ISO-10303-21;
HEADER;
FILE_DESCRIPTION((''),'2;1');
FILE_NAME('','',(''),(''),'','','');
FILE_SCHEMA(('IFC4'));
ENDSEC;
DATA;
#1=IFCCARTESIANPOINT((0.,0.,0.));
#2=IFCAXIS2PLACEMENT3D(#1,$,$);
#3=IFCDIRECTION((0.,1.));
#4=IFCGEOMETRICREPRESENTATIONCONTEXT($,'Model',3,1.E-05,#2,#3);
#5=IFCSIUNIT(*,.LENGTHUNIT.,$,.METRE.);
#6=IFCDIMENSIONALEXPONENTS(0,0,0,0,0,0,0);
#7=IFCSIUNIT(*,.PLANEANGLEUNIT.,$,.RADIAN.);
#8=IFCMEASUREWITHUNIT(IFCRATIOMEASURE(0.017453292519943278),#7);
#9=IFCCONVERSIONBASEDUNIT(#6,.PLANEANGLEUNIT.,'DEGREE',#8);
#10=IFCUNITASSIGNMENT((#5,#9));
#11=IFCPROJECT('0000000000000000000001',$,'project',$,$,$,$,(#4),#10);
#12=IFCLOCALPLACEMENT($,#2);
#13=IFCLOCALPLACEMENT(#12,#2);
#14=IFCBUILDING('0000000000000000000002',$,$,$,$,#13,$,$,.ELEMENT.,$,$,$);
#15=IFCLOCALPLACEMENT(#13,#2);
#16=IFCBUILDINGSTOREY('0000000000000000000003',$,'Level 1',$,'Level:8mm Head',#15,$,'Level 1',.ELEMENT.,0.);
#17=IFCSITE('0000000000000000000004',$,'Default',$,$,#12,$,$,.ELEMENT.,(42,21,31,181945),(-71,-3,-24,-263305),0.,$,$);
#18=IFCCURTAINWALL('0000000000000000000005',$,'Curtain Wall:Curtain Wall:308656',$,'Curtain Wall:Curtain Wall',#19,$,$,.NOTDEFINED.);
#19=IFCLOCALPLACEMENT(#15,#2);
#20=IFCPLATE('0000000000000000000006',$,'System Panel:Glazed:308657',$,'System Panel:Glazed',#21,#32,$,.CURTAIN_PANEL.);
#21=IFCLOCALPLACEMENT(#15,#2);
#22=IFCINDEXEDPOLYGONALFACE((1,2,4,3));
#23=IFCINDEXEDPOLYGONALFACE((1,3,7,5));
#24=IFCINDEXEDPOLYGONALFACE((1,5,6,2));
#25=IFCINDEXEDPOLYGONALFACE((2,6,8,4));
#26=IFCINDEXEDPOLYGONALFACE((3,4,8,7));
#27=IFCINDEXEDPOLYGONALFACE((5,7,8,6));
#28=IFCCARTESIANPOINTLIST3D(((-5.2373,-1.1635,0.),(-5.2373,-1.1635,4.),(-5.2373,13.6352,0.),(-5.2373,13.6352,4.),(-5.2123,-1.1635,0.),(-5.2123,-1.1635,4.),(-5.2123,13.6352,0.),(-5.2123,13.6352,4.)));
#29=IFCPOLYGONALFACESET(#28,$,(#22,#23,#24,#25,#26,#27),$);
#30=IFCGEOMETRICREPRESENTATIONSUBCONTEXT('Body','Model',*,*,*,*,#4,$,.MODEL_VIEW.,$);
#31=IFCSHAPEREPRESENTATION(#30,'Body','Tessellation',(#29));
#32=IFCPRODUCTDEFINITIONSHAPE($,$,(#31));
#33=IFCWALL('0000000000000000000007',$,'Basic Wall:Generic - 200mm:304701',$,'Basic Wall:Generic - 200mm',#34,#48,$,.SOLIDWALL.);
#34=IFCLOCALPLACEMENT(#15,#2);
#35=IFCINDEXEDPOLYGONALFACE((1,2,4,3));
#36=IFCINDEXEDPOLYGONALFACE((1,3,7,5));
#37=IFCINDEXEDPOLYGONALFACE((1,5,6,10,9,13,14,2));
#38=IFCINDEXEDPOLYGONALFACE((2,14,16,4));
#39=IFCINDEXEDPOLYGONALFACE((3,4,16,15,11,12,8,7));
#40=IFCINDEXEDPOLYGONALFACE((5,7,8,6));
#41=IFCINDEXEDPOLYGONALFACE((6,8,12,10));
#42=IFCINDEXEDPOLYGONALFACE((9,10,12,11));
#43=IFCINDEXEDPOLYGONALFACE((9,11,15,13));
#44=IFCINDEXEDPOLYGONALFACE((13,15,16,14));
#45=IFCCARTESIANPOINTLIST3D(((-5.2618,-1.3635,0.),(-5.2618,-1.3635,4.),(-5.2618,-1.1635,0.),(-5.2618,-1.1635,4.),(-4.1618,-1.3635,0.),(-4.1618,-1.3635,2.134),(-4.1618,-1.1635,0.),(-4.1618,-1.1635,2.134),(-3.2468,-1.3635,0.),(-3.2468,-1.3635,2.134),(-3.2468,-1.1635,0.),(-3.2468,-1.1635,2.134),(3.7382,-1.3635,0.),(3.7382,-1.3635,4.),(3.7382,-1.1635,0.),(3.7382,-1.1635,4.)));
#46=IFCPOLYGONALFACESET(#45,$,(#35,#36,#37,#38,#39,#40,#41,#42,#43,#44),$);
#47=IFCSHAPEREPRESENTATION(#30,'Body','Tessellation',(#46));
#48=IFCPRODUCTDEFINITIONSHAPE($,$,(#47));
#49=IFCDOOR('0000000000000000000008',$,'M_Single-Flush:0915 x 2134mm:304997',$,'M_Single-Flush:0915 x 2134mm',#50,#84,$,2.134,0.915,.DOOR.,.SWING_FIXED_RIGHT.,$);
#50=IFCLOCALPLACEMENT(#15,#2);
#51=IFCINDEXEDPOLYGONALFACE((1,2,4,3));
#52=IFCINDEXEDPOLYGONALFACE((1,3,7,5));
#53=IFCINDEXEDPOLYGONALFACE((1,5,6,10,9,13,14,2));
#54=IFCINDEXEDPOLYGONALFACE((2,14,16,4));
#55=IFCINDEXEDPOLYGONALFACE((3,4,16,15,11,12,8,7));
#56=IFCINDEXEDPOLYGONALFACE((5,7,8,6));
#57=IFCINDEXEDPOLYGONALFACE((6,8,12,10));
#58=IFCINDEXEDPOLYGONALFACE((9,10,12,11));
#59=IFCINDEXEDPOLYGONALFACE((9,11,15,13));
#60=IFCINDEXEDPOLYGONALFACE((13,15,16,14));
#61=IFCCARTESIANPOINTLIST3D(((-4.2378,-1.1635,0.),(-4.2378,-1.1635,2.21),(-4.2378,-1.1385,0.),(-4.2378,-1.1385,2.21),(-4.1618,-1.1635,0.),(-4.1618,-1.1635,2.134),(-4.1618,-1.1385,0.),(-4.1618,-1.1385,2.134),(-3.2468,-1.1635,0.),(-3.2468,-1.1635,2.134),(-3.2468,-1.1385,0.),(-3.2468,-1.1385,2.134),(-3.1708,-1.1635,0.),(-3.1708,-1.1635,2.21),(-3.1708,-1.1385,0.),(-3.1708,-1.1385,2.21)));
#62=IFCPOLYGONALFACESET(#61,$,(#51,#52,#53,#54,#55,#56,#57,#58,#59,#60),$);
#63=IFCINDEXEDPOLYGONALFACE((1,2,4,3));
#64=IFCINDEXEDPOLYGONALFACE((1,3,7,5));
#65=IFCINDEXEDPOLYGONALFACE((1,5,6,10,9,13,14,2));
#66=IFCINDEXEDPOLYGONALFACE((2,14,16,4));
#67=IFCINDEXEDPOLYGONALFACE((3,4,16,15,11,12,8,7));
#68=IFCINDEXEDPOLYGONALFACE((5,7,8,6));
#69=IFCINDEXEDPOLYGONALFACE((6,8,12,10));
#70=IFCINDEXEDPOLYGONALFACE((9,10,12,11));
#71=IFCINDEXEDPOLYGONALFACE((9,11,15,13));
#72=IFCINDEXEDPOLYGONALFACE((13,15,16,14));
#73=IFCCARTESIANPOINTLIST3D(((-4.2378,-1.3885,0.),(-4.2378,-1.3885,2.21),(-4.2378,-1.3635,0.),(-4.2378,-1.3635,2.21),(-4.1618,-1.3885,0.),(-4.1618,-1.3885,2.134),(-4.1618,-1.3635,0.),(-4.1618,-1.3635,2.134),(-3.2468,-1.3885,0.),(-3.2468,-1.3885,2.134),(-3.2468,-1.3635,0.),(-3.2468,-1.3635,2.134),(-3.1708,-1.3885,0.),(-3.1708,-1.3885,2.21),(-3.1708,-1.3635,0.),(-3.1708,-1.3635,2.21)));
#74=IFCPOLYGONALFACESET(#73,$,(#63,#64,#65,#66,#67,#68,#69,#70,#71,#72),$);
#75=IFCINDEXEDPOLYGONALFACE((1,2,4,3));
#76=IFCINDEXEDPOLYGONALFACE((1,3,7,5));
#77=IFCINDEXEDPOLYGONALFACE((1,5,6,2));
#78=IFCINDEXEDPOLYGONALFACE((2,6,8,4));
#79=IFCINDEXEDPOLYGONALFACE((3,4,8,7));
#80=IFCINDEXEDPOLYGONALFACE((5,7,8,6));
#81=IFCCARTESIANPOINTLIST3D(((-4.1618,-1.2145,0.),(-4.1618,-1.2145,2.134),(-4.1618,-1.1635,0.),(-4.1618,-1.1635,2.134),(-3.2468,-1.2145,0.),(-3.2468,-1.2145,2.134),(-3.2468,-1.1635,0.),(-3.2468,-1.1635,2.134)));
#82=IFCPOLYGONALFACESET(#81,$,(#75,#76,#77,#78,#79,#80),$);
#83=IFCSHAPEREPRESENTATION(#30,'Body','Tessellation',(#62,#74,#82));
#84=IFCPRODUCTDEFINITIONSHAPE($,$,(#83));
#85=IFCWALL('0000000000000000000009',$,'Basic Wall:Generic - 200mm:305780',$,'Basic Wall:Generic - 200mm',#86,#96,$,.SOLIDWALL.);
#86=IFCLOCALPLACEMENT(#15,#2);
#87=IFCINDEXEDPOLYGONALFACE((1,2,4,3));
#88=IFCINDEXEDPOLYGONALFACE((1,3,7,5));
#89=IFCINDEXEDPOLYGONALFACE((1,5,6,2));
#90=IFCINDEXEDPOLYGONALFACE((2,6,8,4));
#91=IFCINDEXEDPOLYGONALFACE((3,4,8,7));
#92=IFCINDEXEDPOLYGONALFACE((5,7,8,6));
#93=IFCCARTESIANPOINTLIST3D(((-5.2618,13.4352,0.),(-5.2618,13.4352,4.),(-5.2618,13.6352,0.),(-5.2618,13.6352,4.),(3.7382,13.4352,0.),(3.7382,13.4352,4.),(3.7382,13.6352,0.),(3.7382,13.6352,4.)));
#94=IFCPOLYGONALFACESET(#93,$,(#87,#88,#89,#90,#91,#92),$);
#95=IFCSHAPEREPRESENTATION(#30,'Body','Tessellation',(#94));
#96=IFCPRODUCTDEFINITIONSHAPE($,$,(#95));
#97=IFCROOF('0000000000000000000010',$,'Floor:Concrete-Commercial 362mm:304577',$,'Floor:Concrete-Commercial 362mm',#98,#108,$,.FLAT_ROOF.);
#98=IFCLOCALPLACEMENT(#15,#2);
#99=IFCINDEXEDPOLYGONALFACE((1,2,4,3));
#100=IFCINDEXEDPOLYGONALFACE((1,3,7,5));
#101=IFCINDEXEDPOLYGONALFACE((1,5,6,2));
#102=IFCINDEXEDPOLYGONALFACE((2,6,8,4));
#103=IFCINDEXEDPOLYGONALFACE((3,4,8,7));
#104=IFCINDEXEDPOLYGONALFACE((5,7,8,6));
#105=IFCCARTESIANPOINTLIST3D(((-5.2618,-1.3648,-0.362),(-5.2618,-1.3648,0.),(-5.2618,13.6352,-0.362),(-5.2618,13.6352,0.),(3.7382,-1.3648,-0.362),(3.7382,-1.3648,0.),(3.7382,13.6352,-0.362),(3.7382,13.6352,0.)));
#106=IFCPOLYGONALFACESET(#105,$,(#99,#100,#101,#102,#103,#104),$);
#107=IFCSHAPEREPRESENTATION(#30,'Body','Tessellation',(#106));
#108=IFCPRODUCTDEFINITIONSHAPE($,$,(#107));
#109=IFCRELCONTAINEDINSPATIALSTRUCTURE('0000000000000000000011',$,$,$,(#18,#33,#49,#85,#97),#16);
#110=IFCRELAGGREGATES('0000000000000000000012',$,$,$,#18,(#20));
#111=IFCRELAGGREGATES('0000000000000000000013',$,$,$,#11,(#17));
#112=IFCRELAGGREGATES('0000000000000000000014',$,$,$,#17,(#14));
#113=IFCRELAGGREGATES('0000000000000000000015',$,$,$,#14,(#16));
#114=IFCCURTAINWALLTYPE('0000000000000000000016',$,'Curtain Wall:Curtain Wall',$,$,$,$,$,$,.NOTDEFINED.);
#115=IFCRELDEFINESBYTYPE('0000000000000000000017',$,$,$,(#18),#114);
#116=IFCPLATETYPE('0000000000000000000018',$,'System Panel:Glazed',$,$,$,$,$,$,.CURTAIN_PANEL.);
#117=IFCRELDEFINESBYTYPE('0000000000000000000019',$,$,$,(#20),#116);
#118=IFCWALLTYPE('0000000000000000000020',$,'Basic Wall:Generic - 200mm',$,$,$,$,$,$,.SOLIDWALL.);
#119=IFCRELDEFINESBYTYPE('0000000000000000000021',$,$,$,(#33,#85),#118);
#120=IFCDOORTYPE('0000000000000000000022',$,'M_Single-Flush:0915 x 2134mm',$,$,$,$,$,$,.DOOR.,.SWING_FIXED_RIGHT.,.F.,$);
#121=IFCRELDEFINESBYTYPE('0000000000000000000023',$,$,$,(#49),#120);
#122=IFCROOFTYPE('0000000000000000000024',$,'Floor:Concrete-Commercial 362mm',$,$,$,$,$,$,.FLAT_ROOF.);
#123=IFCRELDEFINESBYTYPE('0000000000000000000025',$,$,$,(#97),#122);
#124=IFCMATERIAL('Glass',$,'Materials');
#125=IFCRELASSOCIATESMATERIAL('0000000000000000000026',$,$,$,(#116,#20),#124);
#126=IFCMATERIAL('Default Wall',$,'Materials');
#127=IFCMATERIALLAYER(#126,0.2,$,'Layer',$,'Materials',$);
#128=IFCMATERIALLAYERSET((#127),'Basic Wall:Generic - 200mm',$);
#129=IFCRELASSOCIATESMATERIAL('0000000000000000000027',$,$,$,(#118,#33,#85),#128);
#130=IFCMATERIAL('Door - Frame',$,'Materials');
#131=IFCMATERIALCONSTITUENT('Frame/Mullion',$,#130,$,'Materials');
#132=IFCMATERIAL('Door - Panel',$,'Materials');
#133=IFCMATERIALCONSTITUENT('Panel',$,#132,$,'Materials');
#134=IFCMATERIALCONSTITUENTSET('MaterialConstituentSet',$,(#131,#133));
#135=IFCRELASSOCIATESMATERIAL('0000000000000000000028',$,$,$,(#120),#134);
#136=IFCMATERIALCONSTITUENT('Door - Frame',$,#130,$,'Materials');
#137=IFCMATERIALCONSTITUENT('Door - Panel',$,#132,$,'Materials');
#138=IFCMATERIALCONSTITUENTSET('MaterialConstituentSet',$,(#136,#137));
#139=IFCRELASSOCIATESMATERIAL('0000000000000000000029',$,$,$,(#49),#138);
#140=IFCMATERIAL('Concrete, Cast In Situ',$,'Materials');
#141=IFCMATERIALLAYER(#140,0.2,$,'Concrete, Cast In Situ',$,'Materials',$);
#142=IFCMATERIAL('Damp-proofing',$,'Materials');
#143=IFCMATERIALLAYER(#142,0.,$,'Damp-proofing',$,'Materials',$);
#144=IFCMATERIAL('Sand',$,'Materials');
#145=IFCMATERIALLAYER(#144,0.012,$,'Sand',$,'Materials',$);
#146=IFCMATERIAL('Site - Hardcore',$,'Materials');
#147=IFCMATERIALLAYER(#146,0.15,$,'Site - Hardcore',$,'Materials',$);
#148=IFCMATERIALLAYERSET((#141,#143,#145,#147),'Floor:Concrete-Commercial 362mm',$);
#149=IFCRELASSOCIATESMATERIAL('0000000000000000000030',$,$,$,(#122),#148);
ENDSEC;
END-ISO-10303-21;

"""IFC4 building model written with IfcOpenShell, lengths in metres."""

from ifc_helpers import new_model, entity, si_unit, converted_unit, direction, frame, frame_2d, origin, origin_2d_with_axis, place, context, subcontext, project, spatial, polyline, rectangle, outline, extrude, source, transform, mapped, material, layer, layer_set, layer_usage, constituent, constituent_set, type_object, type_shapes, element, fill, aggregate, save


model = new_model("IFC4")

# Units and contexts
model_context = context("Model", 3, precision=1e-05, world=origin(), true_north=direction((0.0, 1.0)))
body_context = subcontext(model_context, "Body", "Model", "MODEL_VIEW")
ifc_project = project(units=[si_unit("LENGTHUNIT", "METRE"), converted_unit("PLANEANGLEUNIT", "DEGREE", entity("IfcRatioMeasure", 0.017453292519943278), si_unit("PLANEANGLEUNIT", "RADIAN"), dimensions=[0, 0, 0, 0, 0, 0, 0])], contexts=[model_context])

# Site, building, storey
site_placement = place(None, origin())
site = spatial("IfcSite", under=ifc_project, at=site_placement, Name="Default", CompositionType="ELEMENT", RefLatitude=(42, 21, 31, 181945), RefLongitude=(-71, -3, -24, -263305), RefElevation=0.0)
building_placement = place(site_placement, origin())
building = spatial("IfcBuilding", under=site, at=building_placement, CompositionType="ELEMENT")
storey_placement = place(building_placement, origin())
storey = spatial("IfcBuildingStorey", under=building, at=storey_placement, Name="Level 1", ObjectType="Level:8mm Head", LongName="Level 1", CompositionType="ELEMENT", Elevation=0.0)

# Curtain wall, plate
curtain_wall_type = type_object("IfcCurtainWallType", Name="Curtain Wall:Curtain Wall", PredefinedType="NOTDEFINED")
ifc_material_1 = material(Name="Glass", Category="Materials")
curtain_wall_1_placement = place(storey_placement, origin())
curtain_wall_1 = element("IfcCurtainWall", 1, at=curtain_wall_1_placement, inside=storey, type_object=curtain_wall_type, Name="Curtain Wall:Curtain Wall:308656", ObjectType="Curtain Wall:Curtain Wall", PredefinedType="NOTDEFINED")
plate_type_1 = type_object("IfcPlateType", Name="System Panel:Glazed", PredefinedType="CURTAIN_PANEL", material=ifc_material_1)
shared_shape_1 = source(origin(), body_context, "Body", "SweptSolid", [
    extrude(rectangle(XDim=0.025, YDim=14.7987, at=origin_2d_with_axis()), frame((7.3993, 0.0125, 0.0), z_axis=(0.0, 0.0, 1.0), x_axis=(0.0, 1.0, 0.0)), (0.0, 0.0, 1.0), 4.0),
])
type_shapes(plate_type_1, [shared_shape_1])
plate_1_placement = place(curtain_wall_1_placement, frame((-5.2373, 13.6352, 0.0), z_axis=(0.0, 0.0, 1.0), x_axis=(0.0, -1.0, 0.0)))
plate_1 = element("IfcPlate", 2, at=plate_1_placement, type_object=plate_type_1, material=ifc_material_1, Name="System Panel:Glazed:308657", ObjectType="System Panel:Glazed", PredefinedType="CURTAIN_PANEL", context=body_context, shape_type="MappedRepresentation", body=[
    mapped(shared_shape_1, transform((0.0, 0.0, 0.0), scale=1.0)),
])
aggregate(curtain_wall_1, [plate_1])

# Wall, opening, door
ifc_material_2 = material(Name="Default Wall", Category="Materials")
ifc_layer_1 = layer(ifc_material_2, 0.2, Name="Layer", Category="Materials")
ifc_layer_set_1 = layer_set([ifc_layer_1], Name="Basic Wall:Generic - 200mm")
ifc_layer_usage_1 = layer_usage(ifc_layer_set_1, "AXIS2", "NEGATIVE", 0.1)
wall_type = type_object("IfcWallType", Name="Basic Wall:Generic - 200mm", PredefinedType="SOLIDWALL", material=ifc_layer_set_1)
wall_1_placement = place(storey_placement, frame((-5.2618, -1.2635, 0.0)))
wall_1 = element("IfcWall", 3, at=wall_1_placement, inside=storey, type_object=wall_type, material=ifc_layer_usage_1, Name="Basic Wall:Generic - 200mm:304701", ObjectType="Basic Wall:Generic - 200mm", PredefinedType="SOLIDWALL", context=body_context, shape_type="SweptSolid", body=[
    extrude(rectangle(XDim=9.0, YDim=0.2, at=frame_2d((4.5, 0.0), x_axis=(1.0, 0.0))), origin(), (0.0, 0.0, 1.0), 4.0),
])
opening_placement = place(wall_1_placement, frame((1.1, -0.1, 0.0)))
opening = element("IfcOpeningElement", 4, at=opening_placement, cuts=wall_1, PredefinedType="OPENING", context=body_context, shape_type="SweptSolid", body=[
    extrude(rectangle(XDim=0.915, YDim=2.134, at=frame_2d((1.067, 0.4575), x_axis=(0.0, 1.0))), frame((0.0, 0.0, 0.0), z_axis=(0.0, 1.0, 0.0), x_axis=(0.0, 0.0, 1.0)), (0.0, 0.0, 1.0), 0.2),
])
ifc_material_3 = material(Name="Door - Frame", Category="Materials")
ifc_constituent_1 = constituent(ifc_material_3, Name="Door - Frame", Category="Materials")
ifc_material_4 = material(Name="Door - Panel", Category="Materials")
ifc_constituent_2 = constituent(ifc_material_4, Name="Door - Panel", Category="Materials")
ifc_constituent_set_1 = constituent_set(constituents=[ifc_constituent_1, ifc_constituent_2], Name="MaterialConstituentSet")
ifc_constituent_3 = constituent(ifc_material_3, Name="Frame/Mullion", Category="Materials")
ifc_constituent_4 = constituent(ifc_material_4, Name="Panel", Category="Materials")
ifc_constituent_set_2 = constituent_set(constituents=[ifc_constituent_3, ifc_constituent_4], Name="MaterialConstituentSet")
door_type = type_object("IfcDoorType", Name="M_Single-Flush:0915 x 2134mm", OperationType="SWING_FIXED_RIGHT", ParameterTakesPrecedence=False, PredefinedType="DOOR", material=ifc_constituent_set_2)
shared_shape_2 = source(origin(), body_context, "Body", "SweptSolid", [
    extrude(outline(polyline([(-0.5335, -1.124), (0.5335, -1.124), (0.5335, 1.086), (0.4575, 1.086), (0.4575, -1.048), (-0.4575, -1.048), (-0.4575, 1.086), (-0.5335, 1.086), (-0.5335, -1.124)])), frame((0.4575, 0.2, 1.086), z_axis=(0.0, 1.0, 0.0), x_axis=(1.0, 0.0, 0.0)), (0.0, 0.0, 1.0), 0.025),
    extrude(outline(polyline([(-1.124, -0.5335), (1.086, -0.5335), (1.086, -0.4575), (-1.048, -0.4575), (-1.048, 0.4575), (1.086, 0.4575), (1.086, 0.5335), (-1.124, 0.5335), (-1.124, -0.5335)])), frame((0.4575, -0.025, 1.086), z_axis=(0.0, 1.0, 0.0), x_axis=(0.0, 0.0, -1.0)), (0.0, 0.0, 1.0), 0.025),
    extrude(rectangle(XDim=0.051, YDim=0.915, at=frame_2d((0.0, 0.0), x_axis=(1.0, 0.0))), frame((0.4575, 0.1745, 0.0), z_axis=(0.0, 0.0, 1.0), x_axis=(0.0, 1.0, 0.0)), (0.0, 0.0, 1.0), 2.134),
])
type_shapes(door_type, [shared_shape_2])
door_placement = place(opening_placement, origin())
door = element("IfcDoor", 5, at=door_placement, inside=storey, type_object=door_type, material=ifc_constituent_set_1, Name="M_Single-Flush:0915 x 2134mm:304997", ObjectType="M_Single-Flush:0915 x 2134mm", OperationType="SWING_FIXED_RIGHT", OverallHeight=2.134, OverallWidth=0.915, PredefinedType="DOOR", context=body_context, shape_type="MappedRepresentation", body=[
    mapped(shared_shape_2, transform((0.0, 0.0, 0.0), scale=1.0)),
])
fill(opening, door)

# Wall
ifc_layer_usage_2 = layer_usage(ifc_layer_set_1, "AXIS2", "NEGATIVE", 0.1)
wall_2_placement = place(storey_placement, frame((-5.2618, 13.5352, 0.0)))
element("IfcWall", 6, at=wall_2_placement, inside=storey, type_object=wall_type, material=ifc_layer_usage_2, Name="Basic Wall:Generic - 200mm:305780", ObjectType="Basic Wall:Generic - 200mm", PredefinedType="SOLIDWALL", context=body_context, shape_type="SweptSolid", body=[
    extrude(rectangle(XDim=9.0, YDim=0.2, at=frame_2d((4.5, 0.0), x_axis=(-1.0, 0.0))), origin(), (0.0, 0.0, 1.0), 4.0),
])

# Roof
ifc_material_5 = material(Name="Concrete, Cast In Situ", Category="Materials")
ifc_layer_2 = layer(ifc_material_5, 0.2, Name="Concrete, Cast In Situ", Category="Materials")
ifc_material_6 = material(Name="Damp-proofing", Category="Materials")
ifc_layer_3 = layer(ifc_material_6, 0.0, Name="Damp-proofing", Category="Materials")
ifc_material_7 = material(Name="Sand", Category="Materials")
ifc_layer_4 = layer(ifc_material_7, 0.012, Name="Sand", Category="Materials")
ifc_material_8 = material(Name="Site - Hardcore", Category="Materials")
ifc_layer_5 = layer(ifc_material_8, 0.15, Name="Site - Hardcore", Category="Materials")
ifc_layer_set_2 = layer_set([ifc_layer_2, ifc_layer_3, ifc_layer_4, ifc_layer_5], Name="Floor:Concrete-Commercial 362mm")
roof_type = type_object("IfcRoofType", Name="Floor:Concrete-Commercial 362mm", PredefinedType="FLAT_ROOF", material=ifc_layer_set_2)
roof_placement = place(storey_placement, origin())
element("IfcRoof", 7, at=roof_placement, inside=storey, type_object=roof_type, Name="Floor:Concrete-Commercial 362mm:304577", ObjectType="Floor:Concrete-Commercial 362mm", PredefinedType="FLAT_ROOF", context=body_context, shape_type="SweptSolid", body=[
    extrude(rectangle(XDim=15.0, YDim=9.0, at=origin_2d_with_axis()), frame((-0.7618, 6.1352, 0.0), z_axis=(0.0, 0.0, -1.0), x_axis=(0.0, 1.0, 0.0)), (0.0, 0.0, 1.0), 0.362),
])

save(model, "model.ifc")
